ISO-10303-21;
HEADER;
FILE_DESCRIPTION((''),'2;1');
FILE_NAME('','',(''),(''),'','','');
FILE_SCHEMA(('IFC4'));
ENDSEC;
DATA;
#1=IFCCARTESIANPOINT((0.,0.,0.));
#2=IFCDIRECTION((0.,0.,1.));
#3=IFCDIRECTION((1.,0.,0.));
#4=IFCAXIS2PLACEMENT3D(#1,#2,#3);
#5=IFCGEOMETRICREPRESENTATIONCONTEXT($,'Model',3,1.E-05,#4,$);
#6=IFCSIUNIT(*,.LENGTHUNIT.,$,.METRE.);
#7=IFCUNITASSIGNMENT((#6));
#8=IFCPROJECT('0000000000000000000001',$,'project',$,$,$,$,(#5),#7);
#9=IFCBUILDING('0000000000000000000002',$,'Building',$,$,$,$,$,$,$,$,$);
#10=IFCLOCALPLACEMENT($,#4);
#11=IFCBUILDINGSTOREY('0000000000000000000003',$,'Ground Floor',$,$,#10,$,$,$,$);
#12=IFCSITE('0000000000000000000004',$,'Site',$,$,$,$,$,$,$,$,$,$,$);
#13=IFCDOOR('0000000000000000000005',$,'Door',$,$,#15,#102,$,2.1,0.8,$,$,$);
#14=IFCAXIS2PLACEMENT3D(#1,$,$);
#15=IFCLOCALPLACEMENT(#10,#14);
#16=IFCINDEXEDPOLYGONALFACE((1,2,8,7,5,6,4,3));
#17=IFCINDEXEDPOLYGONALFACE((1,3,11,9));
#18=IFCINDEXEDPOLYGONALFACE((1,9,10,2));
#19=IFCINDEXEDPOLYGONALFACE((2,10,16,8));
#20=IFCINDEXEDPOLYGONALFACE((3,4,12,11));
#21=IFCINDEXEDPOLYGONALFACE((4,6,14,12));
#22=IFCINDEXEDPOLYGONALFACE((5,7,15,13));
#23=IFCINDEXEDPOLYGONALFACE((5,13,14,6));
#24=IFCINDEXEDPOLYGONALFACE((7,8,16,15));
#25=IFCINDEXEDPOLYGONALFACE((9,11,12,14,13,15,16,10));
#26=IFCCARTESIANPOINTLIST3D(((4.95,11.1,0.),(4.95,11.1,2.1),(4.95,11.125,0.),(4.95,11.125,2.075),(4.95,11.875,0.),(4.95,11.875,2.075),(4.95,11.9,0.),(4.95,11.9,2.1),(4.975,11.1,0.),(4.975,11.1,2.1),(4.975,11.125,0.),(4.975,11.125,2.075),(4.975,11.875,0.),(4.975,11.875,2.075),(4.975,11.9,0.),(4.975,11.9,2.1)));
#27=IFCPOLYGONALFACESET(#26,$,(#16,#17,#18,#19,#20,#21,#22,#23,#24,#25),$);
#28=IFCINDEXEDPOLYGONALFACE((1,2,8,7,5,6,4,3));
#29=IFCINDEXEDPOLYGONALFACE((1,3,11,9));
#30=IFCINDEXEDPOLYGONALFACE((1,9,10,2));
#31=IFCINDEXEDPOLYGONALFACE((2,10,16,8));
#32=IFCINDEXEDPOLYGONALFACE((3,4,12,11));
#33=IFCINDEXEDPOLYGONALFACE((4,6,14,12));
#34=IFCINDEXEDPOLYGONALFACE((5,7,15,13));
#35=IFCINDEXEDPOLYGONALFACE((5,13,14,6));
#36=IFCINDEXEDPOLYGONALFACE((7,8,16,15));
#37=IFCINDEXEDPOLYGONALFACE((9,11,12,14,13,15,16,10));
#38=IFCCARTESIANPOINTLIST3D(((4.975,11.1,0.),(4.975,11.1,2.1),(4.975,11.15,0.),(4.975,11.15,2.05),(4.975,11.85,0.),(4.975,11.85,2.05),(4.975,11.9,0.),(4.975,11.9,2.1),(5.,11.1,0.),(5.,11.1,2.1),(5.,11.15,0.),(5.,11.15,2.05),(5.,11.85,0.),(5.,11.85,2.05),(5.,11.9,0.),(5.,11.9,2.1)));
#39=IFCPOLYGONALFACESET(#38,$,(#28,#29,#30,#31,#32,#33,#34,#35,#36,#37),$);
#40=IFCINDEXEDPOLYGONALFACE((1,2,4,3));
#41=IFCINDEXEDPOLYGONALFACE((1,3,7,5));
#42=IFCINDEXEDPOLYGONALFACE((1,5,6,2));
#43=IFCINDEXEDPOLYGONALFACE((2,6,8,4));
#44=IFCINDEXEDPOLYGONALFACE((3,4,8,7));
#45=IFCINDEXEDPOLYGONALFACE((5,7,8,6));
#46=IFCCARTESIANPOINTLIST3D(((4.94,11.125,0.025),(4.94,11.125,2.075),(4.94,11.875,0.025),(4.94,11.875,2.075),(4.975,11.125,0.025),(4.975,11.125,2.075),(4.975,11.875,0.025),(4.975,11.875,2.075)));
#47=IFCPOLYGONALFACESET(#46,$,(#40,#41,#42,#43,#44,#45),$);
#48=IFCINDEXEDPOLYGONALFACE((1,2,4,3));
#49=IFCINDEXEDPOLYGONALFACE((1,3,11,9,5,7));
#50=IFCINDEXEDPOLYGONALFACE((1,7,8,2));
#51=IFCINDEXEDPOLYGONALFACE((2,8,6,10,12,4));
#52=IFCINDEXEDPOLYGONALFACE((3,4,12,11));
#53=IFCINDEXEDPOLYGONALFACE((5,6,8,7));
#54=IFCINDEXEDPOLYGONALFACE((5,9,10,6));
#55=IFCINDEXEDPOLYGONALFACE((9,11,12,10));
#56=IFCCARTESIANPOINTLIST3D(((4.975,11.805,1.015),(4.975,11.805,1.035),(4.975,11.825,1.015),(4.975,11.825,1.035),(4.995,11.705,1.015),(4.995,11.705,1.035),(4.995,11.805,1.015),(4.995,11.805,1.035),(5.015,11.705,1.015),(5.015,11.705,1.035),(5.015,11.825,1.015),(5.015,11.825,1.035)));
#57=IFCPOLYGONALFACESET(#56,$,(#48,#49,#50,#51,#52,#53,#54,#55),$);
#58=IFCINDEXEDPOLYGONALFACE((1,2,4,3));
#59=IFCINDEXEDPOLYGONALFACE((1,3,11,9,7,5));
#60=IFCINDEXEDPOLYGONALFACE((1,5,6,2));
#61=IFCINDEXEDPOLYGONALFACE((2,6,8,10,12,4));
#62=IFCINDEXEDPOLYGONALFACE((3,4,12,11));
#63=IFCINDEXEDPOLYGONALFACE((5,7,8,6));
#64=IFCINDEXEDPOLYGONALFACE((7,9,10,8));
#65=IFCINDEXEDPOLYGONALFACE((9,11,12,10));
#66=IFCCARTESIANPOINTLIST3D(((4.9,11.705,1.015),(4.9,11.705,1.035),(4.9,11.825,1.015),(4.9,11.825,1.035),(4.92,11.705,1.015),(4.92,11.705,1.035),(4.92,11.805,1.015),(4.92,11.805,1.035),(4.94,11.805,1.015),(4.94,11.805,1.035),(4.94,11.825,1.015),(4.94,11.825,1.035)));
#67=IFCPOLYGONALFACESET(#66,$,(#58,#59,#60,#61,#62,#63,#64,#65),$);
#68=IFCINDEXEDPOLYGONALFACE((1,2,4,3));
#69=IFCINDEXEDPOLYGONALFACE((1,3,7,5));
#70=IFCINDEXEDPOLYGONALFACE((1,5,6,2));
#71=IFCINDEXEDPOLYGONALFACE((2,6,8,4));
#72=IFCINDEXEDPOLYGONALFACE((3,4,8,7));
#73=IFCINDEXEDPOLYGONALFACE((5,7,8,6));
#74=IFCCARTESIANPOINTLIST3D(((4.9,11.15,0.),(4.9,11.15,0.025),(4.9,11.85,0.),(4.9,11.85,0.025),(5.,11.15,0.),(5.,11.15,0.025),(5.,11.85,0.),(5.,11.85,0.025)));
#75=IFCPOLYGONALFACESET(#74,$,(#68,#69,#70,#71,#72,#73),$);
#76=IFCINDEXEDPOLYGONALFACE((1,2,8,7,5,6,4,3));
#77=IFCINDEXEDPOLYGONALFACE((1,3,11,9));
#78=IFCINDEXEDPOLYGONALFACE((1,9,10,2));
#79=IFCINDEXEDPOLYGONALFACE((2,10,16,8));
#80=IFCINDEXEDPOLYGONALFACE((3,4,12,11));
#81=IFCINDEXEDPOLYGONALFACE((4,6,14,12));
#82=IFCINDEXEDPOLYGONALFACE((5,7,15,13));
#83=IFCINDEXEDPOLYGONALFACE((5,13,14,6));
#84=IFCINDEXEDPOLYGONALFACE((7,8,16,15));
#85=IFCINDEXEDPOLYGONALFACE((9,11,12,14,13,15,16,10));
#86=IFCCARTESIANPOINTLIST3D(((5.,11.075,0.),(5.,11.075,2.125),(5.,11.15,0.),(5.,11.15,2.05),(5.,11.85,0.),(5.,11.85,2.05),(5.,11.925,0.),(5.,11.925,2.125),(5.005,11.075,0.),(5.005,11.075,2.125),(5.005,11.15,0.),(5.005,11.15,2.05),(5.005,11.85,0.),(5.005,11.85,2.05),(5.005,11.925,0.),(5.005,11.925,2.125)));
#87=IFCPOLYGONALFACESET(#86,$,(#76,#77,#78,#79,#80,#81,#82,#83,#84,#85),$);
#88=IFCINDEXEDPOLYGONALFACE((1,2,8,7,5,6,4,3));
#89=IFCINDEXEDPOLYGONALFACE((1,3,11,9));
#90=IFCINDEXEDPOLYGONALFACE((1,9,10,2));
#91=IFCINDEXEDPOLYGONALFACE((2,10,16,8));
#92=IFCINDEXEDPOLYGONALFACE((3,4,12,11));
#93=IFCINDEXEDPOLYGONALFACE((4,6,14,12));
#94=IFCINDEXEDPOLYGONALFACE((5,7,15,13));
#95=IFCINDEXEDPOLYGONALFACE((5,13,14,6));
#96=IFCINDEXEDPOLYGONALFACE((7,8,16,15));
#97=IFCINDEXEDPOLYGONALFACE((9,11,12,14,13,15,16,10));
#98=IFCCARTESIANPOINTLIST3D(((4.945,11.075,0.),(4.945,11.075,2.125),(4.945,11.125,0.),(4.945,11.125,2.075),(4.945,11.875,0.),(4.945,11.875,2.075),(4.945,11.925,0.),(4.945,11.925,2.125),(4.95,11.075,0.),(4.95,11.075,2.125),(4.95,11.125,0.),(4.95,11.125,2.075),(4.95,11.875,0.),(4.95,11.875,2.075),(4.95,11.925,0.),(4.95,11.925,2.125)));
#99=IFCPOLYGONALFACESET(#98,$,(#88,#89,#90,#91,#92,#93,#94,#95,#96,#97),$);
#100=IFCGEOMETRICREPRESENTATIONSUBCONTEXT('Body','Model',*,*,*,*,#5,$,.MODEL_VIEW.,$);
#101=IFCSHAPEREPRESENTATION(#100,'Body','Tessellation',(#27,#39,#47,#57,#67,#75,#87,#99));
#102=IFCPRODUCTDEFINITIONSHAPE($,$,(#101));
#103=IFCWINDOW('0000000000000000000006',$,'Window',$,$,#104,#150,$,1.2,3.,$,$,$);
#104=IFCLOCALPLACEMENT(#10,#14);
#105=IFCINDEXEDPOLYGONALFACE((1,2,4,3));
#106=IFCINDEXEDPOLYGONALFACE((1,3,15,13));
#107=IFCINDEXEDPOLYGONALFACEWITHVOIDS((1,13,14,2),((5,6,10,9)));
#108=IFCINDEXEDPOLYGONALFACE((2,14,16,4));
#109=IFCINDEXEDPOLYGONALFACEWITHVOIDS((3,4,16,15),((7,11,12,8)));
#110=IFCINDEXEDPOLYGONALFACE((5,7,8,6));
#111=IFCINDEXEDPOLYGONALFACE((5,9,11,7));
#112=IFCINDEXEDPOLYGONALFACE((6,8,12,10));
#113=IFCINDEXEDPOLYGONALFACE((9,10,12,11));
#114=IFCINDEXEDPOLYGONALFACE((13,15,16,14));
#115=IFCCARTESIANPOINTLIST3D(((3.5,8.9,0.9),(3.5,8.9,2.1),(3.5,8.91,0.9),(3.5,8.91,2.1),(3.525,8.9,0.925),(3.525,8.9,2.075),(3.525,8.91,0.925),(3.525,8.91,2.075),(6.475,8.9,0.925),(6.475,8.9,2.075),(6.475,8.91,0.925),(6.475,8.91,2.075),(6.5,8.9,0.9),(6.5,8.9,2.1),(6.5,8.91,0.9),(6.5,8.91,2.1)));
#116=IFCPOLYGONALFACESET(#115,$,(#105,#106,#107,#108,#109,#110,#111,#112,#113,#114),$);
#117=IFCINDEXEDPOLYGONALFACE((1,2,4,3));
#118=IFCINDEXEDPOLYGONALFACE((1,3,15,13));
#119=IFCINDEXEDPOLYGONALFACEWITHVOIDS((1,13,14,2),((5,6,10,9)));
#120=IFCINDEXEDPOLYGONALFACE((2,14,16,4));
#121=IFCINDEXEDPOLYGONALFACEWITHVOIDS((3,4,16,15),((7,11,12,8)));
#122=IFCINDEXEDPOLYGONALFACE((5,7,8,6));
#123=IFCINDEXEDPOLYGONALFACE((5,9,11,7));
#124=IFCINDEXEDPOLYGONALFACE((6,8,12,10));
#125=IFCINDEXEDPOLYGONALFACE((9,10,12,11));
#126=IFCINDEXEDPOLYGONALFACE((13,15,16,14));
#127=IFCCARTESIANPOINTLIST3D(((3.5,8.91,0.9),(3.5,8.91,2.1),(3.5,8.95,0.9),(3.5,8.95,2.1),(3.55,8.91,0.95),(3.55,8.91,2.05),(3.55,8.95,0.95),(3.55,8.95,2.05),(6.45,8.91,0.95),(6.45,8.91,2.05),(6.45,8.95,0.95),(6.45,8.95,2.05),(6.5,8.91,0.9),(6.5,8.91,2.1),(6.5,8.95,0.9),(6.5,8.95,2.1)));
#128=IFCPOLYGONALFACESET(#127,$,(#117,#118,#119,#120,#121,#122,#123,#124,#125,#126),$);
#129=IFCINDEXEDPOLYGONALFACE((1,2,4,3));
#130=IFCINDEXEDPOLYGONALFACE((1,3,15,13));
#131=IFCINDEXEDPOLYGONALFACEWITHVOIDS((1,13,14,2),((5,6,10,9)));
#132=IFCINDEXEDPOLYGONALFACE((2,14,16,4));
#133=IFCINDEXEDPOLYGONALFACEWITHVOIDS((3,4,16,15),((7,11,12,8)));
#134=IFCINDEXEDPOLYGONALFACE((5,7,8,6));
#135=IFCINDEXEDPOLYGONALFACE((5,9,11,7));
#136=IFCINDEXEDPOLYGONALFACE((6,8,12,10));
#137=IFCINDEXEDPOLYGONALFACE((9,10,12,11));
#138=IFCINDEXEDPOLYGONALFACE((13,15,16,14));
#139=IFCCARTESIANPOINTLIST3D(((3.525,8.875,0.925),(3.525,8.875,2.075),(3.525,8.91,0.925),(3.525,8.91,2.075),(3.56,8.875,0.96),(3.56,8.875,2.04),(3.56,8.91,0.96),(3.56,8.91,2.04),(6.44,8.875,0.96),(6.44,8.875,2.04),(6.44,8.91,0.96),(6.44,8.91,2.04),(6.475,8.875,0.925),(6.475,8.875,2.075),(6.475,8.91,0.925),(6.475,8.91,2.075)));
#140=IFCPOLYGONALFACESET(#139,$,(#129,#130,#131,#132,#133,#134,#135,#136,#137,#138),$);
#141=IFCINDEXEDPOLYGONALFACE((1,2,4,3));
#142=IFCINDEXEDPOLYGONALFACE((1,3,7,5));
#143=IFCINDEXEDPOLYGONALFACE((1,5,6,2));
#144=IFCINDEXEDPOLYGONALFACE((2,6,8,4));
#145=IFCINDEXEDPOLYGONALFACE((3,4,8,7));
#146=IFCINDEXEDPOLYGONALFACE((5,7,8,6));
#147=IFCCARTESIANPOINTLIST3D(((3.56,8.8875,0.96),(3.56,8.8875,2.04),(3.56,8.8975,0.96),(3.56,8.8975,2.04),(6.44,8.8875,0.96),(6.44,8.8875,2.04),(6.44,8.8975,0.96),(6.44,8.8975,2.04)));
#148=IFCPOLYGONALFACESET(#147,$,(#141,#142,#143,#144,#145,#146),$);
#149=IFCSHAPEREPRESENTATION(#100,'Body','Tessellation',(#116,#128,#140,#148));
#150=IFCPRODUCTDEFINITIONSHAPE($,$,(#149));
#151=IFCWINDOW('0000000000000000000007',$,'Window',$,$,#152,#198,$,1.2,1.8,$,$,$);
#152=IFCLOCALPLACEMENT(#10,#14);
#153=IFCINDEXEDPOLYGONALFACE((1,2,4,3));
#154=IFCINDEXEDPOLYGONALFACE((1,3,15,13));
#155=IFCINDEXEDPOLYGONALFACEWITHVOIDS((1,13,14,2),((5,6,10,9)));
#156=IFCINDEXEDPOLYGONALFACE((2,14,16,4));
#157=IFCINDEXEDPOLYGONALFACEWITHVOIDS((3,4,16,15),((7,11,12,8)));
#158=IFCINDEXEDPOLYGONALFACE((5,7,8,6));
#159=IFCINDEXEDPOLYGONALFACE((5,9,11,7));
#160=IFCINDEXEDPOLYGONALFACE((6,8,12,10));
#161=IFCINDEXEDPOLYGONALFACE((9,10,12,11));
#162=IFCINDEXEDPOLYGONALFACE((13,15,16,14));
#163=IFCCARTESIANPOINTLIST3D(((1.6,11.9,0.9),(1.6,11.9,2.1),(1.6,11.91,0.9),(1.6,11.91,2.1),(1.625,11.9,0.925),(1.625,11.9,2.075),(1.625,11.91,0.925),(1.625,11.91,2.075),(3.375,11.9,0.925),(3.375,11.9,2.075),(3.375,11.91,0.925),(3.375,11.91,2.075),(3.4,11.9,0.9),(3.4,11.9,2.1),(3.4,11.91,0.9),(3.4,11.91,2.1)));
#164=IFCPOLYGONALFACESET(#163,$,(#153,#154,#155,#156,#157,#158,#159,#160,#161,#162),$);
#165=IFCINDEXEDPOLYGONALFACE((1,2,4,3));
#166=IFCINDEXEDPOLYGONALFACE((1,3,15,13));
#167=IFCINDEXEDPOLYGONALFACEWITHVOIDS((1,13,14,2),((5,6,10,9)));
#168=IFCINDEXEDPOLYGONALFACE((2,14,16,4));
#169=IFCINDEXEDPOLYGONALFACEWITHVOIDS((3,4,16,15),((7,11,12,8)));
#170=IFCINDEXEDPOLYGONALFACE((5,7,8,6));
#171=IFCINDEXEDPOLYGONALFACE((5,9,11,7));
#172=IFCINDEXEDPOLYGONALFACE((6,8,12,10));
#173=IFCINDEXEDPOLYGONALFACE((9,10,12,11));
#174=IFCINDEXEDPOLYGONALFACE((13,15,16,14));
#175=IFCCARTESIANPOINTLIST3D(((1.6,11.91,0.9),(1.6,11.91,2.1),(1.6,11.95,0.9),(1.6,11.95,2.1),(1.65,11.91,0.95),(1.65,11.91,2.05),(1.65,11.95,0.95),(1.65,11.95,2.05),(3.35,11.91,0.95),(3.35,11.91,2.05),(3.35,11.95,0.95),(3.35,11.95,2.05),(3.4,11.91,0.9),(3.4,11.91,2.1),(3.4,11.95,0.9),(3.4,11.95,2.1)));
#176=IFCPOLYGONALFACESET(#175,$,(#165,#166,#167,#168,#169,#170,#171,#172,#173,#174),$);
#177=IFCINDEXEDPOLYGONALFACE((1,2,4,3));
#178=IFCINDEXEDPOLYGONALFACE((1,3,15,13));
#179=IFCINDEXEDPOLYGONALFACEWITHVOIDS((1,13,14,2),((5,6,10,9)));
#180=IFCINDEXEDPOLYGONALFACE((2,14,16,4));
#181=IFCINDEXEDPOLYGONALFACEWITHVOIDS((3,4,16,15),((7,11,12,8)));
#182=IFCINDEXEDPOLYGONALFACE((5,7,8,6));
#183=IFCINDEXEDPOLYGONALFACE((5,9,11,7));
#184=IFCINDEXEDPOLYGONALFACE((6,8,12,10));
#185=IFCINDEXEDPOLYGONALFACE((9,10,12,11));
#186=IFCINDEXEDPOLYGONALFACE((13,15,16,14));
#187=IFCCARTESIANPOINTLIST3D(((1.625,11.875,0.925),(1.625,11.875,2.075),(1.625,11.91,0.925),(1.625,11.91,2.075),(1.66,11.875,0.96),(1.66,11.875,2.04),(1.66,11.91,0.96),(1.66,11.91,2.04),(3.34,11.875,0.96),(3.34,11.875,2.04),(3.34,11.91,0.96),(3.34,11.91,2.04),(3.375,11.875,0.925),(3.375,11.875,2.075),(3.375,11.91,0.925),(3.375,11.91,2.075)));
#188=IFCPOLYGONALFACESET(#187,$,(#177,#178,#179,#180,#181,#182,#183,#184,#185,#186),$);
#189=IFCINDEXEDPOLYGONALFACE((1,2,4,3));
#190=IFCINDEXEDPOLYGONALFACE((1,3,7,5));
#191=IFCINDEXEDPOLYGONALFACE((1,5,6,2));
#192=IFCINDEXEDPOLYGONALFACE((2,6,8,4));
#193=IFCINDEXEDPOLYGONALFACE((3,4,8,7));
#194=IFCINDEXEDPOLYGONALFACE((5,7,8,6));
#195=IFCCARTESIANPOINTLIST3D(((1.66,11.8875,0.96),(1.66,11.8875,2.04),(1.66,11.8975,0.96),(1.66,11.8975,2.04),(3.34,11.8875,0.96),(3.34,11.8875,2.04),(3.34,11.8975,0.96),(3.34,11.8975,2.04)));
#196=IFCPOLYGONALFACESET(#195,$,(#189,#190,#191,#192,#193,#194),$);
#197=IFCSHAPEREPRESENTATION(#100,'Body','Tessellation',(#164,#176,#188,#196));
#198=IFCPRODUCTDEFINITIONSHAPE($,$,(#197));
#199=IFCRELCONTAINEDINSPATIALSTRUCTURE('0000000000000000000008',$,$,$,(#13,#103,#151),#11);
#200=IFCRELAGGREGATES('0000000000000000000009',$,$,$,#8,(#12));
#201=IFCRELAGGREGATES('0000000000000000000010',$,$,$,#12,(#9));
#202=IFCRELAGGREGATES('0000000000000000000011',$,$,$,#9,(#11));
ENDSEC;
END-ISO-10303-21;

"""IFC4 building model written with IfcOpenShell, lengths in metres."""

from ifc_helpers import new_model, si_unit, frame, origin_with_axes, place, context, subcontext, project, spatial, line, indexed_curve, outline, extrude, element, save


model = new_model("IFC4")

# Units and contexts
model_context = context("Model", 3, precision=1e-05, world=origin_with_axes())
body_context = subcontext(model_context, "Body", "Model", "MODEL_VIEW")
ifc_project = project(units=[si_unit("LENGTHUNIT", "METRE")], contexts=[model_context])

# Site, building, storey
site = spatial("IfcSite", under=ifc_project, Name="Site")
building = spatial("IfcBuilding", under=site, Name="Building")
storey_placement = place(None, origin_with_axes())
storey = spatial("IfcBuildingStorey", under=building, at=storey_placement, Name="Ground Floor")

# Door
door_1_placement = place(storey_placement, frame((5.0, 11.1, 0.0), z_axis=(0.0, 0.0, 1.0), x_axis=(0.0, 1.0, 0.0)))
element("IfcDoor", 1, at=door_1_placement, inside=storey, Name="Door", OverallHeight=2.1, OverallWidth=0.8, context=body_context, shape_type="SweptSolid", body=[
    extrude(outline(indexed_curve([(0.0, 0.0), (0.0, 2.1), (0.8, 2.1), (0.8, 0.0), (0.775, 0.0), (0.775, 2.075), (0.025, 2.075), (0.025, 0.0)], segments=[line(1, 2, 3, 4, 5, 6, 7, 8, 1)])), frame((0.0, 0.025, 0.0), z_axis=(0.0, -1.0, 0.0), x_axis=(1.0, 0.0, 0.0)), (0.0, 0.0, -1.0), 0.025),
    extrude(outline(indexed_curve([(0.0, 0.0), (0.0, 2.1), (0.8, 2.1), (0.8, 0.0), (0.75, 0.0), (0.75, 2.05), (0.05, 2.05), (0.05, 0.0)], segments=[line(1, 2, 3, 4, 5, 6, 7, 8, 1)])), frame((0.0, 0.0, 0.0), z_axis=(0.0, -1.0, 0.0), x_axis=(1.0, 0.0, 0.0)), (0.0, 0.0, -1.0), 0.025),
    extrude(outline(indexed_curve([(0.0, 0.0), (0.75, 0.0), (0.75, 0.035), (0.0, 0.035)], segments=[line(1, 2, 3, 4, 1)])), frame((0.025, 0.025, 0.025), z_axis=(0.0, 0.0, 1.0), x_axis=(1.0, 0.0, 0.0)), (0.0, 0.0, 1.0), 2.05),
    extrude(outline(indexed_curve([(0.0, 0.0), (0.0, -0.04), (-0.12, -0.04), (-0.12, -0.02), (-0.02, -0.02), (-0.02, 0.0)], segments=[line(1, 2, 3, 4, 5, 6, 1)])), frame((0.725, 0.025, 1.015), z_axis=(0.0, 0.0, 1.0), x_axis=(1.0, 0.0, 0.0)), (0.0, 0.0, 1.0), 0.02),
    extrude(outline(indexed_curve([(0.0, 0.0), (0.0, 0.04), (-0.12, 0.04), (-0.12, 0.02), (-0.02, 0.02), (-0.02, 0.0)], segments=[line(1, 2, 3, 4, 5, 6, 1)])), frame((0.725, 0.06, 1.015), z_axis=(0.0, 0.0, 1.0), x_axis=(1.0, 0.0, 0.0)), (0.0, 0.0, 1.0), 0.02),
    extrude(outline(indexed_curve([(0.0, 0.0), (0.7, 0.0), (0.7, 0.1), (0.0, 0.1)], segments=[line(1, 2, 3, 4, 1)])), frame((0.05, 0.0, 0.0), z_axis=(0.0, 0.0, 1.0), x_axis=(1.0, 0.0, 0.0)), (0.0, 0.0, 1.0), 0.025),
    extrude(outline(indexed_curve([(0.0, 0.0), (0.0, 2.125), (0.85, 2.125), (0.85, 0.0), (0.775, 0.0), (0.775, 2.05), (0.075, 2.05), (0.075, 0.0)], segments=[line(1, 2, 3, 4, 5, 6, 7, 8, 1)])), frame((-0.025, -0.005, 0.0), z_axis=(0.0, -1.0, 0.0), x_axis=(1.0, 0.0, 0.0)), (0.0, 0.0, -1.0), 0.005),
    extrude(outline(indexed_curve([(0.0, 0.0), (0.0, 2.125), (0.85, 2.125), (0.85, 0.0), (0.8, 0.0), (0.8, 2.075), (0.05, 2.075), (0.05, 0.0)], segments=[line(1, 2, 3, 4, 5, 6, 7, 8, 1)])), frame((-0.025, 0.05, 0.0), z_axis=(0.0, -1.0, 0.0), x_axis=(1.0, 0.0, 0.0)), (0.0, 0.0, -1.0), 0.005),
])

# Windows
window_1_placement = place(storey_placement, frame((6.5, 9.0, 0.9), z_axis=(0.0, 0.0, 1.0), x_axis=(-1.0, 0.0, 0.0)))
element("IfcWindow", 2, at=window_1_placement, inside=storey, Name="Window", OverallHeight=1.2, OverallWidth=3.0, context=body_context, shape_type="SweptSolid", body=[
    extrude(outline(indexed_curve([(0.0, 0.0), (3.0, 0.0), (3.0, 1.2), (0.0, 1.2)], segments=[line(1, 2, 3, 4, 1)]), holes=[indexed_curve([(0.025, 0.025), (2.975, 0.025), (2.975, 1.175), (0.025, 1.175)], segments=[line(1, 2, 3, 4, 1)])]), frame((0.0, 0.09, 0.0), z_axis=(0.0, -1.0, 0.0), x_axis=(1.0, 0.0, 0.0)), (0.0, 0.0, -1.0), 0.01),
    extrude(outline(indexed_curve([(0.0, 0.0), (3.0, 0.0), (3.0, 1.2), (0.0, 1.2)], segments=[line(1, 2, 3, 4, 1)]), holes=[indexed_curve([(0.05, 0.05), (2.95, 0.05), (2.95, 1.15), (0.05, 1.15)], segments=[line(1, 2, 3, 4, 1)])]), frame((0.0, 0.05, 0.0), z_axis=(0.0, -1.0, 0.0), x_axis=(1.0, 0.0, 0.0)), (0.0, 0.0, -1.0), 0.04),
    extrude(outline(indexed_curve([(0.0, 0.0), (2.95, 0.0), (2.95, 1.15), (0.0, 1.15)], segments=[line(1, 2, 3, 4, 1)]), holes=[indexed_curve([(0.035, 0.035), (2.915, 0.035), (2.915, 1.115), (0.035, 1.115)], segments=[line(1, 2, 3, 4, 1)])]), frame((0.025, 0.09, 0.025), z_axis=(0.0, -1.0, 0.0), x_axis=(1.0, 0.0, 0.0)), (0.0, 0.0, -1.0), 0.035),
    extrude(outline(indexed_curve([(0.035, 0.035), (2.915, 0.035), (2.915, 1.115), (0.035, 1.115)], segments=[line(1, 2, 3, 4, 1)])), frame((0.025, 0.1025, 0.025), z_axis=(0.0, -1.0, 0.0), x_axis=(1.0, 0.0, 0.0)), (0.0, 0.0, -1.0), 0.01),
])
window_2_placement = place(storey_placement, frame((3.4, 12.0, 0.9), z_axis=(0.0, 0.0, 1.0), x_axis=(-1.0, 0.0, 0.0)))
element("IfcWindow", 3, at=window_2_placement, inside=storey, Name="Window", OverallHeight=1.2, OverallWidth=1.8, context=body_context, shape_type="SweptSolid", body=[
    extrude(outline(indexed_curve([(0.0, 0.0), (1.8, 0.0), (1.8, 1.2), (0.0, 1.2)], segments=[line(1, 2, 3, 4, 1)]), holes=[indexed_curve([(0.025, 0.025), (1.775, 0.025), (1.775, 1.175), (0.025, 1.175)], segments=[line(1, 2, 3, 4, 1)])]), frame((0.0, 0.09, 0.0), z_axis=(0.0, -1.0, 0.0), x_axis=(1.0, 0.0, 0.0)), (0.0, 0.0, -1.0), 0.01),
    extrude(outline(indexed_curve([(0.0, 0.0), (1.8, 0.0), (1.8, 1.2), (0.0, 1.2)], segments=[line(1, 2, 3, 4, 1)]), holes=[indexed_curve([(0.05, 0.05), (1.75, 0.05), (1.75, 1.15), (0.05, 1.15)], segments=[line(1, 2, 3, 4, 1)])]), frame((0.0, 0.05, 0.0), z_axis=(0.0, -1.0, 0.0), x_axis=(1.0, 0.0, 0.0)), (0.0, 0.0, -1.0), 0.04),
    extrude(outline(indexed_curve([(0.0, 0.0), (1.75, 0.0), (1.75, 1.15), (0.0, 1.15)], segments=[line(1, 2, 3, 4, 1)]), holes=[indexed_curve([(0.035, 0.035), (1.715, 0.035), (1.715, 1.115), (0.035, 1.115)], segments=[line(1, 2, 3, 4, 1)])]), frame((0.025, 0.09, 0.025), z_axis=(0.0, -1.0, 0.0), x_axis=(1.0, 0.0, 0.0)), (0.0, 0.0, -1.0), 0.035),
    extrude(outline(indexed_curve([(0.035, 0.035), (1.715, 0.035), (1.715, 1.115), (0.035, 1.115)], segments=[line(1, 2, 3, 4, 1)])), frame((0.025, 0.1025, 0.025), z_axis=(0.0, -1.0, 0.0), x_axis=(1.0, 0.0, 0.0)), (0.0, 0.0, -1.0), 0.01),
])

save(model, "model.ifc")
